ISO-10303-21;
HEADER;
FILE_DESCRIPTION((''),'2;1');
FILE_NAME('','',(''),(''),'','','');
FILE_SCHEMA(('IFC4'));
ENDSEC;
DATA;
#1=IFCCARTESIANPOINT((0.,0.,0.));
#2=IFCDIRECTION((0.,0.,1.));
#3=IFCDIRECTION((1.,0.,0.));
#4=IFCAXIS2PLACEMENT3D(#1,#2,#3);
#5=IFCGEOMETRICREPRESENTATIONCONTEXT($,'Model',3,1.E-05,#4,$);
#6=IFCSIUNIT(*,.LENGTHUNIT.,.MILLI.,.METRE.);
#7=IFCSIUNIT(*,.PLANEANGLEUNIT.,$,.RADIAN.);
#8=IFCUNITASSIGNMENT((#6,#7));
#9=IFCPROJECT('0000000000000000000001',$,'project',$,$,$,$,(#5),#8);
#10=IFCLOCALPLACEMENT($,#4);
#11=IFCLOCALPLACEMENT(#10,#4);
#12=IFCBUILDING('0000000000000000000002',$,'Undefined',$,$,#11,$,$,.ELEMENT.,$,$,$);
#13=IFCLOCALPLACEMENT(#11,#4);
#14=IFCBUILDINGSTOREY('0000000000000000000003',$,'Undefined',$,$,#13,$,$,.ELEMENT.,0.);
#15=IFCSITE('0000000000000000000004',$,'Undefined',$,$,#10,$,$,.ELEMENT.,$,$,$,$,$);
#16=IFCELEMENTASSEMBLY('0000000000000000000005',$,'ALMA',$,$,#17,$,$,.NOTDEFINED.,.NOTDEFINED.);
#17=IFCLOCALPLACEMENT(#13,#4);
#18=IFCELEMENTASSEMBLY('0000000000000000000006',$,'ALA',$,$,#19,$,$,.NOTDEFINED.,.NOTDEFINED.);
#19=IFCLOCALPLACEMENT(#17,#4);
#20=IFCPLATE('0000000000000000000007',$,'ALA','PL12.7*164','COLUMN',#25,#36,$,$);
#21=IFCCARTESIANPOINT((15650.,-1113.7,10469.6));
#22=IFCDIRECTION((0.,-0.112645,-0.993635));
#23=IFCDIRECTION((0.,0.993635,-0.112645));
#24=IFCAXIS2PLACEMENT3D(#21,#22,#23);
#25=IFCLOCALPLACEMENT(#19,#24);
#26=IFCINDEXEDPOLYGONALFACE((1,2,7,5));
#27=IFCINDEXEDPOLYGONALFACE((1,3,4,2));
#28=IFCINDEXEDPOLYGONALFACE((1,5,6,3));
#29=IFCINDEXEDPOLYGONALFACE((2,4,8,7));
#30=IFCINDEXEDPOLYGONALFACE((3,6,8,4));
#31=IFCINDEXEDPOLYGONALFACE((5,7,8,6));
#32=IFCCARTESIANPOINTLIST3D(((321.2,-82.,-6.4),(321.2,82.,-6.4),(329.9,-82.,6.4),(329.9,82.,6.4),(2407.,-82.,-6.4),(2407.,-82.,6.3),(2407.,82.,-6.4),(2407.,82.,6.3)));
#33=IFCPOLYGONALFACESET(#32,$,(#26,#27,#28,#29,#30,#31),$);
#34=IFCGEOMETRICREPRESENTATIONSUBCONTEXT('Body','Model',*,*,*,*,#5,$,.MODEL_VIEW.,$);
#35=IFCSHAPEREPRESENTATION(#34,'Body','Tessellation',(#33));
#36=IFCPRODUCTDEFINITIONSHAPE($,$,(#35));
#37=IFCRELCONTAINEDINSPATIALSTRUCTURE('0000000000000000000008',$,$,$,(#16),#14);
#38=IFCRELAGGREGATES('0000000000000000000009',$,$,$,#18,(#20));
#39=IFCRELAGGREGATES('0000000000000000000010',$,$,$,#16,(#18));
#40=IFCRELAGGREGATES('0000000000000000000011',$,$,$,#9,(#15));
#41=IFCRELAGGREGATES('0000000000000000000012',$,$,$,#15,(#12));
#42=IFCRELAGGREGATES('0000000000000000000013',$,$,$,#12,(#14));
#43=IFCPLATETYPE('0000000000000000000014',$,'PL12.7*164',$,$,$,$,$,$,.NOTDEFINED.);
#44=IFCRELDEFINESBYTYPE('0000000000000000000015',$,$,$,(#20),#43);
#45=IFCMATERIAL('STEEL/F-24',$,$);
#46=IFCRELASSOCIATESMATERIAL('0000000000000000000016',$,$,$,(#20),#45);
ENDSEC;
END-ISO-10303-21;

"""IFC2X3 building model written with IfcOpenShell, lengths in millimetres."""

from ifc_helpers import new_model, si_unit, frame, origin_with_axes, place, context, subcontext, project, spatial, polyline, outline, extrude, boolean, material, type_object, element, aggregate, save


model = new_model("IFC2X3")

# Units and contexts
model_context = context("Model", 3, precision=1e-05, world=origin_with_axes())
body_context = subcontext(model_context, "Body", "Model", "MODEL_VIEW")
ifc_project = project(units=[si_unit("LENGTHUNIT", "METRE", prefix="MILLI"), si_unit("PLANEANGLEUNIT", "RADIAN")], contexts=[model_context])

# Site, building, storey
site_placement = place(None, origin_with_axes())
site = spatial("IfcSite", under=ifc_project, at=site_placement, Name="Undefined", CompositionType="ELEMENT")
building_placement = place(site_placement, origin_with_axes())
building = spatial("IfcBuilding", under=site, at=building_placement, Name="Undefined", CompositionType="ELEMENT")
storey_placement = place(building_placement, origin_with_axes())
storey = spatial("IfcBuildingStorey", under=building, at=storey_placement, Name="Undefined", CompositionType="ELEMENT", Elevation=0.0)

# Shared definitions
ifc_material_1 = material(Name="STEEL/F-24")

# Element assembly
assembly_1_placement = place(storey_placement, origin_with_axes())
assembly_1 = element("IfcElementAssembly", 1, at=assembly_1_placement, inside=storey, Name="ALMA", AssemblyPlace="NOTDEFINED", PredefinedType="NOTDEFINED")

# Element assembly, plate
assembly_2_placement = place(assembly_1_placement, origin_with_axes())
assembly_2 = element("IfcElementAssembly", 2, at=assembly_2_placement, Name="ALA", AssemblyPlace="NOTDEFINED", PredefinedType="NOTDEFINED")
plate_type_1 = type_object("IfcPlateType", Name="PL12.7*164", PredefinedType="NOTDEFINED")
plate_1_placement = place(assembly_2_placement, frame((15650.0, -1113.7, 10469.6), z_axis=(0.0, -0.112645, -0.993635), x_axis=(0.0, 0.993635, -0.112645)))
plate_1 = element("IfcPlate", 3, at=plate_1_placement, type_object=plate_type_1, material=ifc_material_1, Name="ALA", Description="PL12.7*164", ObjectType="COLUMN", context=body_context, shape_type="CSG", body=[
    boolean("DIFFERENCE", extrude(outline(polyline([(321.2, -82.0), (321.2, 82.0), (2407.0, 82.0), (2407.0, -82.0), (321.2, -82.0)])), frame((0.0, 0.0, -6.3), z_axis=(0.0, 0.0, 1.0), x_axis=(1.0, 0.0, 0.0)), (0.0, 0.0, 1.0), 12.7), extrude(outline(polyline([(0.0, 0.0), (584.4, 0.0), (186.2, 272.3), (0.0, 0.0)])), frame((329.9, -84.5, 6.4), z_axis=(0.0, 1.0, 0.0), x_axis=(-0.564512, 0.0, -0.825425)), (0.0, 0.0, 1.0), 169.0)),
])
aggregate(assembly_2, [plate_1])

aggregate(assembly_1, [assembly_2])

save(model, "model.ifc")
